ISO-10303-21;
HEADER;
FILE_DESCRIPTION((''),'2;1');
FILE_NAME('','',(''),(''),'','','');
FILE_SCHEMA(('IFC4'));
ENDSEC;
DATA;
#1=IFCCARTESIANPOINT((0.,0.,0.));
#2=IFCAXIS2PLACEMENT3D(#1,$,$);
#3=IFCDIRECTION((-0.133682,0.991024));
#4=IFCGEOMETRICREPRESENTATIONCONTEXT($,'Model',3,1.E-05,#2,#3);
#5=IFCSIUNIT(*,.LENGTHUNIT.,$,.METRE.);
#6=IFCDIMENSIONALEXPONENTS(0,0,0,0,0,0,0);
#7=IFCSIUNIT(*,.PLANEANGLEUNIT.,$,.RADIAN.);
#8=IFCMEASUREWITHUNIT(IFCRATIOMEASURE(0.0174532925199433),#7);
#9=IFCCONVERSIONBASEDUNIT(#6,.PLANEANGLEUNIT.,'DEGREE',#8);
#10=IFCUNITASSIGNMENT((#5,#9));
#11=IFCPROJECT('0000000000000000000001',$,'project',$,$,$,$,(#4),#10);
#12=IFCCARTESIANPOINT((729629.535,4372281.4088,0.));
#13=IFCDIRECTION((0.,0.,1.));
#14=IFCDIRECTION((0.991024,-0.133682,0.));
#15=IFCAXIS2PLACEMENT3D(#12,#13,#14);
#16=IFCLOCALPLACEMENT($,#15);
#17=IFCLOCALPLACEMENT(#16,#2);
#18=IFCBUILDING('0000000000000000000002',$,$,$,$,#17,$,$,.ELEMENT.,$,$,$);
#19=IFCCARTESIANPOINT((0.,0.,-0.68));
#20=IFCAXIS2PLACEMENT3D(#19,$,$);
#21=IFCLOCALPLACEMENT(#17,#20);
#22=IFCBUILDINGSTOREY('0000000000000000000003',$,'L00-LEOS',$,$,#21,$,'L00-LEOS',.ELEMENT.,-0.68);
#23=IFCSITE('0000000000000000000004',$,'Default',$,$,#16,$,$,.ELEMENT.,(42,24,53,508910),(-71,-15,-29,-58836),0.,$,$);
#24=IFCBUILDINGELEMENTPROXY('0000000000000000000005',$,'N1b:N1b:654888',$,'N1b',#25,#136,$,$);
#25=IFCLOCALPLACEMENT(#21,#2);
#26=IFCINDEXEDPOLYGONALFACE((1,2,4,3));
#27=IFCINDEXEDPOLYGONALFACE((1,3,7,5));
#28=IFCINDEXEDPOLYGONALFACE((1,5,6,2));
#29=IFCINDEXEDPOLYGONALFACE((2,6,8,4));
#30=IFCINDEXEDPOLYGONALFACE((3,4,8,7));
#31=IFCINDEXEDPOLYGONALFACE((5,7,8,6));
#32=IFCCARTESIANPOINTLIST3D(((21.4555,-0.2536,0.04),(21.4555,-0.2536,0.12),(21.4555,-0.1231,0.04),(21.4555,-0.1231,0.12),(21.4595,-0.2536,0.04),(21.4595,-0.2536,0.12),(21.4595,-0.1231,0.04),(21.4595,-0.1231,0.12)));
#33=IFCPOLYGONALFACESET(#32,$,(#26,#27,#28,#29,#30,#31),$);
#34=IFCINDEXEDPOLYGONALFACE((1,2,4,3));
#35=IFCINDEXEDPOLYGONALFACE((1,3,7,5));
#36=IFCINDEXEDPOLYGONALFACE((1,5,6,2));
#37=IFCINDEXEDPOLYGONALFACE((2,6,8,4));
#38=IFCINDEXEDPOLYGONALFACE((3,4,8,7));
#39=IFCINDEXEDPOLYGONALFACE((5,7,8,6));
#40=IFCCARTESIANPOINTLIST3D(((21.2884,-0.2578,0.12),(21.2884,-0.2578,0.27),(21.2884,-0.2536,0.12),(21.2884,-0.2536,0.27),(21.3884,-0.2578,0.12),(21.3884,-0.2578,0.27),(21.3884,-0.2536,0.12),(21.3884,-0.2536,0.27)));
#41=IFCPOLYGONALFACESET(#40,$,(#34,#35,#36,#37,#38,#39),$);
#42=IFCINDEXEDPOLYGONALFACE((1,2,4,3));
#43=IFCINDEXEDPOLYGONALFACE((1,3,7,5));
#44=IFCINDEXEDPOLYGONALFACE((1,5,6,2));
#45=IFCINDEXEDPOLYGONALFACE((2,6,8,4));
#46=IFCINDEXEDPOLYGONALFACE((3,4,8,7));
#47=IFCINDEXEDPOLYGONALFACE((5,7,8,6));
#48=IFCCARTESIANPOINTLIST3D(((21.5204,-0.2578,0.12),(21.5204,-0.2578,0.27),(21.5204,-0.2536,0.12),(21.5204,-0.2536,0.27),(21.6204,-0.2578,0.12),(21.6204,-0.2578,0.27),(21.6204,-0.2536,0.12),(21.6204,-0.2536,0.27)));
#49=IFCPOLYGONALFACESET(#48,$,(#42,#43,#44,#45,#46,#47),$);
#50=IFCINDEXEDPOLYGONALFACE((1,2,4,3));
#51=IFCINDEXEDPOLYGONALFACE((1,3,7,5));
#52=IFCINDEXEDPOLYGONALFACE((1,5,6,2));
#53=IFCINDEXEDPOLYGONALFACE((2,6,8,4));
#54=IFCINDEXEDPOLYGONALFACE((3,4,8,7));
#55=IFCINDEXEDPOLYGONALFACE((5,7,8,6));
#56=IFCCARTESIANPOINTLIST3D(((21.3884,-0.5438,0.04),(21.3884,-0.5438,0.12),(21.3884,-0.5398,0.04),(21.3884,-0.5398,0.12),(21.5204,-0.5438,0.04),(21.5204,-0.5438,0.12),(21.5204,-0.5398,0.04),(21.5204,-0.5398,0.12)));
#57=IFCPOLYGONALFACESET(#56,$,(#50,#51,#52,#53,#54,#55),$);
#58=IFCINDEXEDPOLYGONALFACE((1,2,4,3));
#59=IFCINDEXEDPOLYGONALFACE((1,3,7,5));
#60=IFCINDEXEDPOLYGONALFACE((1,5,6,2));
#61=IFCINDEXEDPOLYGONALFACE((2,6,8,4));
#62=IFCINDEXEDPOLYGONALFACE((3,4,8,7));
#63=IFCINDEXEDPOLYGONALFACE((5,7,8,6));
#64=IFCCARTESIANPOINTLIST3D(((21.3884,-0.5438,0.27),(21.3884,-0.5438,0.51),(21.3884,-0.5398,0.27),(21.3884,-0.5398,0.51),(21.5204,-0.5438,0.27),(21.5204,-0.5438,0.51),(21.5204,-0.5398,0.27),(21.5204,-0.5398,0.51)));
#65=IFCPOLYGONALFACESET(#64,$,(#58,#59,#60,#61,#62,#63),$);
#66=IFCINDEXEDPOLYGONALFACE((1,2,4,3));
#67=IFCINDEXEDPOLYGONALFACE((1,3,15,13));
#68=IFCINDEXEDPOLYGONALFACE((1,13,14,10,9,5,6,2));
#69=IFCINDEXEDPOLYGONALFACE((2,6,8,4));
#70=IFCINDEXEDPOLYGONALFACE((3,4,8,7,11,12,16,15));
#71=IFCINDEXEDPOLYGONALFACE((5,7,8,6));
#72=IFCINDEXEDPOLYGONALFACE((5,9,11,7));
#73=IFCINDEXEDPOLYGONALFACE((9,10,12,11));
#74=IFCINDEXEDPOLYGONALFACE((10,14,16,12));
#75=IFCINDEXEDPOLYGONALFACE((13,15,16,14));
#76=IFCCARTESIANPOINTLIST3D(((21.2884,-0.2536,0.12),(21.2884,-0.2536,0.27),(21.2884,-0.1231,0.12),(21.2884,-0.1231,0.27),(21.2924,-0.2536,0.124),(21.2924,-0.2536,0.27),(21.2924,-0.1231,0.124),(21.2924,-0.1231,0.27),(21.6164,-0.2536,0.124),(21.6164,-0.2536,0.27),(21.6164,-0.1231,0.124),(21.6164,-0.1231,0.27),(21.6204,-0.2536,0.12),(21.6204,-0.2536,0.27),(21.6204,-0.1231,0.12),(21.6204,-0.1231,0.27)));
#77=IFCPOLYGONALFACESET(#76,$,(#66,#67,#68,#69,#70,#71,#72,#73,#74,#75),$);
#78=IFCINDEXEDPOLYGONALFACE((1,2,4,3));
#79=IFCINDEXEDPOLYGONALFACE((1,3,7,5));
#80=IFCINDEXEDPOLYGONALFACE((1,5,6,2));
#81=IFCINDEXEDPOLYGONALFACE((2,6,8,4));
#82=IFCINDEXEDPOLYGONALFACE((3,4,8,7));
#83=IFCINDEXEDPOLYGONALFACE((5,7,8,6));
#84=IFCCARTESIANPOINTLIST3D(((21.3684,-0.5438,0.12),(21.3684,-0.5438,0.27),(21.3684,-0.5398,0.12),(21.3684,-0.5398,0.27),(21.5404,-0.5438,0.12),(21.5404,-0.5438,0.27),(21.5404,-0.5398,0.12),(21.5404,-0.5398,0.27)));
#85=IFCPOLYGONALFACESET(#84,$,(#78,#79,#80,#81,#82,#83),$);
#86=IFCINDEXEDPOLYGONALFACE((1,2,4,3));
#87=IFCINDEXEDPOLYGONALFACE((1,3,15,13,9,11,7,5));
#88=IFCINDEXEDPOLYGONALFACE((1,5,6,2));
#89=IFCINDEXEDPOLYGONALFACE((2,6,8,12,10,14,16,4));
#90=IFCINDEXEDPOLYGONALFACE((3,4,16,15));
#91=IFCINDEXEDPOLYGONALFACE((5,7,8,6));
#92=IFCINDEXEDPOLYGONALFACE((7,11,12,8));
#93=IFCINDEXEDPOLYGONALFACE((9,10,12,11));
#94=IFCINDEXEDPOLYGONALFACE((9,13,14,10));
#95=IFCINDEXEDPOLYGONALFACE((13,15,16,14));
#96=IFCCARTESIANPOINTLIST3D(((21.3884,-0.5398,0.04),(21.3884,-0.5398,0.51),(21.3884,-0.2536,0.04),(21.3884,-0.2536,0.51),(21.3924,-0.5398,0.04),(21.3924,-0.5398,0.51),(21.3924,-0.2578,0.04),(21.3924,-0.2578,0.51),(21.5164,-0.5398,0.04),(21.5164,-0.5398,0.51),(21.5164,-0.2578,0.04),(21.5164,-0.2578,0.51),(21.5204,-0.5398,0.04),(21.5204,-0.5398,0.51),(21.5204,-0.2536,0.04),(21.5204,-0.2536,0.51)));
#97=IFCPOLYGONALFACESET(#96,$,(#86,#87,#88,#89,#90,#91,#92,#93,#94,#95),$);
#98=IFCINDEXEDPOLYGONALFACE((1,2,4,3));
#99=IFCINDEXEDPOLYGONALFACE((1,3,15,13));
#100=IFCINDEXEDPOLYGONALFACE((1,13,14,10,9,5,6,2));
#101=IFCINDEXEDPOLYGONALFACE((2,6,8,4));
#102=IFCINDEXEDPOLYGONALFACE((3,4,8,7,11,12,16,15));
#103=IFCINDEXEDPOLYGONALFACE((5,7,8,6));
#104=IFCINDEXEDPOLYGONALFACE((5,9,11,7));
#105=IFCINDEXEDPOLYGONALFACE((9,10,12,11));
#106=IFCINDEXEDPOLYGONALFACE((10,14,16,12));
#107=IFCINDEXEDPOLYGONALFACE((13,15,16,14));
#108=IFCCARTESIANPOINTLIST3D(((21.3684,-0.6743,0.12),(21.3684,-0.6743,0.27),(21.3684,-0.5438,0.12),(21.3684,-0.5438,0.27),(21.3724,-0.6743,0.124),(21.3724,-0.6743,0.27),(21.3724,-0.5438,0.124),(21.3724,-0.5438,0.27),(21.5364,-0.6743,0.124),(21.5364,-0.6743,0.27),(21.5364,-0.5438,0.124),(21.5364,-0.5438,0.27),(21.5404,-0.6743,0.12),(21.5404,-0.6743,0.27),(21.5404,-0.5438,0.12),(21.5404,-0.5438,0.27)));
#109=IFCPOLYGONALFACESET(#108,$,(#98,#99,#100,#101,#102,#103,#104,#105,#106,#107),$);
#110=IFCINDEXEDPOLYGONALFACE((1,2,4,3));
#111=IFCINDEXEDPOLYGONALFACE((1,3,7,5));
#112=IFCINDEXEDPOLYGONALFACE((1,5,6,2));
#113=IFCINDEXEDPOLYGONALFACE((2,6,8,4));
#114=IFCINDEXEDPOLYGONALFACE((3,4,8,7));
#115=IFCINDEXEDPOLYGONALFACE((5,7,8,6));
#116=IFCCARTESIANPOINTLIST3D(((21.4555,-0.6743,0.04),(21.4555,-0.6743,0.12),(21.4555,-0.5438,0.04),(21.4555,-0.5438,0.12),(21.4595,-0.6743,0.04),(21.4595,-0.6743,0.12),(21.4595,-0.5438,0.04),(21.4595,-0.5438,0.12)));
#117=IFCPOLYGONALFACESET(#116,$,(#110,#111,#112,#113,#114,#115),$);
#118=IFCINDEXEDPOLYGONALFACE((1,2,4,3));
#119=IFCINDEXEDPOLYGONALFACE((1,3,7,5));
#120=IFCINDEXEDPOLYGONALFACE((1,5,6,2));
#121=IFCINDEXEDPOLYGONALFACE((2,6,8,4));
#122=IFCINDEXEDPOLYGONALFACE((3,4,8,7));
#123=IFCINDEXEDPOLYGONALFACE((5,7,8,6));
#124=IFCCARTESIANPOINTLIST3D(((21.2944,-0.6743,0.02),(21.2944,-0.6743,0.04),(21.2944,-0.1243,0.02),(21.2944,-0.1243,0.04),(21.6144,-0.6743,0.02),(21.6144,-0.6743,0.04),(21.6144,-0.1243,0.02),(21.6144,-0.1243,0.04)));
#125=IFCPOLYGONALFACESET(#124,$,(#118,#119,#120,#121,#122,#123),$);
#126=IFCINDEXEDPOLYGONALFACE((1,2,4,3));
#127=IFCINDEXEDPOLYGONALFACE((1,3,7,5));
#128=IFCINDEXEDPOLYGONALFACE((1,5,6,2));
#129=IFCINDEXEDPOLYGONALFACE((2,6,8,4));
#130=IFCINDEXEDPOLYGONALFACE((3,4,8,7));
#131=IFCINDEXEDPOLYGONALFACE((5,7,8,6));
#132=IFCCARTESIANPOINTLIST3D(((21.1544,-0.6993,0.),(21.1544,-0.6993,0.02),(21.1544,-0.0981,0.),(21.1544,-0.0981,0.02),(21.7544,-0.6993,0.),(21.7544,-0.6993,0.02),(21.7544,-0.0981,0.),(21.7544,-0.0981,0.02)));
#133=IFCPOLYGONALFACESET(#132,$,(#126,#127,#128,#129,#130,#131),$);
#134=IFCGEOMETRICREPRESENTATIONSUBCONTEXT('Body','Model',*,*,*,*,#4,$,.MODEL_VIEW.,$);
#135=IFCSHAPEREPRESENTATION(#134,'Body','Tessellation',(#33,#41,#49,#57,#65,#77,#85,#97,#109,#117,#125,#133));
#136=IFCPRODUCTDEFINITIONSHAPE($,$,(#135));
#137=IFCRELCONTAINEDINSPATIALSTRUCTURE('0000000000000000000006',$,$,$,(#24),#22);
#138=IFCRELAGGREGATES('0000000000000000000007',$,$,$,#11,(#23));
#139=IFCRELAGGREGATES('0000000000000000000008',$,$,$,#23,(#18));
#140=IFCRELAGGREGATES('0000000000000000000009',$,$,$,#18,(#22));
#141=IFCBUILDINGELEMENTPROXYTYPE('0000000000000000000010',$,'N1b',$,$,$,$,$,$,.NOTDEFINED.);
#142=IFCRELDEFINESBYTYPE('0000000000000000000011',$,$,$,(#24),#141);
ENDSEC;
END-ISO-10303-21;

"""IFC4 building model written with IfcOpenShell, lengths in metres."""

from ifc_helpers import new_model, entity, si_unit, converted_unit, direction, frame, frame_2d, origin, origin_2d_with_axis, place, context, subcontext, project, spatial, polyline, rectangle, outline, extrude, source, transform, mapped, type_object, type_shapes, element, save


model = new_model("IFC4")

# Units and contexts
model_context = context("Model", 3, precision=1e-05, world=origin(), true_north=direction((-0.133682, 0.991024)))
body_context = subcontext(model_context, "Body", "Model", "MODEL_VIEW")
ifc_project = project(units=[si_unit("LENGTHUNIT", "METRE"), converted_unit("PLANEANGLEUNIT", "DEGREE", entity("IfcRatioMeasure", 0.0174532925199433), si_unit("PLANEANGLEUNIT", "RADIAN"), dimensions=[0, 0, 0, 0, 0, 0, 0])], contexts=[model_context])

# Site, building, storey
site_placement = place(None, frame((729629.535, 4372281.4088, 0.0), z_axis=(0.0, 0.0, 1.0), x_axis=(0.991024, -0.133682, 0.0)))
site = spatial("IfcSite", under=ifc_project, at=site_placement, Name="Default", CompositionType="ELEMENT", RefLatitude=(42, 24, 53, 508910), RefLongitude=(-71, -15, -29, -58836), RefElevation=0.0)
building_placement = place(site_placement, origin())
building = spatial("IfcBuilding", under=site, at=building_placement, CompositionType="ELEMENT")
storey_placement = place(building_placement, frame((0.0, 0.0, -0.68)))
storey = spatial("IfcBuildingStorey", under=building, at=storey_placement, Name="L00-LEOS", LongName="L00-LEOS", CompositionType="ELEMENT", Elevation=-0.68)

# Building element proxy
building_element_proxy_type_1 = type_object("IfcBuildingElementProxyType", Name="N1b")
shared_shape_1 = source(origin(), body_context, "Body", "SweptSolid", [
    extrude(rectangle(XDim=0.004, YDim=0.1305, at=origin_2d_with_axis()), frame((0.2103, 0.0, 0.04), z_axis=(0.0, 0.0, 1.0), x_axis=(0.0, -1.0, 0.0)), (0.0, 0.0, 1.0), 0.08),
    extrude(rectangle(XDim=0.1, YDim=0.0042, at=frame_2d((0.0, 0.0), x_axis=(1.0, 0.0))), frame((0.143, 0.1191, 0.12), z_axis=(0.0, 0.0, 1.0), x_axis=(0.0, 1.0, 0.0)), (0.0, 0.0, 1.0), 0.15),
    extrude(rectangle(XDim=0.1, YDim=0.0042, at=origin_2d_with_axis()), frame((0.143, -0.1129, 0.12), z_axis=(0.0, 0.0, 1.0), x_axis=(0.0, 1.0, 0.0)), (0.0, 0.0, 1.0), 0.15),
    extrude(rectangle(XDim=0.132, YDim=0.004, at=frame_2d((0.0, 0.0), x_axis=(1.0, 0.0))), frame((-0.1431, 0.0031, 0.04), z_axis=(0.0, 0.0, 1.0), x_axis=(0.0, 1.0, 0.0)), (0.0, 0.0, 1.0), 0.08),
    extrude(rectangle(XDim=0.132, YDim=0.004, at=frame_2d((0.0, 0.0), x_axis=(1.0, 0.0))), frame((-0.1431, 0.0031, 0.27), z_axis=(0.0, 0.0, 1.0), x_axis=(0.0, 1.0, 0.0)), (0.0, 0.0, 1.0), 0.24),
    extrude(outline(polyline([(-0.076, -0.166), (0.074, -0.166), (0.074, -0.162), (-0.072, -0.162), (-0.072, 0.162), (0.074, 0.162), (0.074, 0.166), (-0.076, 0.166), (-0.076, -0.166)])), frame((0.1451, 0.0031, 0.196), z_axis=(1.0, 0.0, 0.0), x_axis=(0.0, 0.0, 1.0)), (0.0, 0.0, 1.0), 0.1305),
    extrude(rectangle(XDim=0.172, YDim=0.004, at=frame_2d((0.0, 0.0), x_axis=(1.0, 0.0))), frame((-0.1431, 0.0031, 0.12), z_axis=(0.0, 0.0, 1.0), x_axis=(0.0, 1.0, 0.0)), (0.0, 0.0, 1.0), 0.15),
    extrude(outline(polyline([(-0.1441, -0.066), (0.142, -0.066), (0.142, -0.062), (-0.14, -0.062), (-0.14, 0.062), (0.142, 0.062), (0.142, 0.066), (-0.1441, 0.066), (-0.1441, -0.066)])), frame((0.001, 0.0031, 0.04), z_axis=(0.0, 0.0, 1.0), x_axis=(-1.0, 0.0, 0.0)), (0.0, 0.0, 1.0), 0.47),
    extrude(outline(polyline([(-0.076, -0.086), (0.074, -0.086), (0.074, -0.082), (-0.072, -0.082), (-0.072, 0.082), (0.074, 0.082), (0.074, 0.086), (-0.076, 0.086), (-0.076, -0.086)])), frame((-0.2756, 0.0031, 0.196), z_axis=(1.0, 0.0, 0.0), x_axis=(0.0, 0.0, 1.0)), (0.0, 0.0, 1.0), 0.1305),
    extrude(rectangle(XDim=0.004, YDim=0.1305, at=origin_2d_with_axis()), frame((-0.2103, 0.0, 0.04), z_axis=(0.0, 0.0, 1.0), x_axis=(0.0, -1.0, 0.0)), (0.0, 0.0, 1.0), 0.08),
    extrude(rectangle(XDim=0.55, YDim=0.32, at=frame_2d((0.0, 0.0), x_axis=(1.0, 0.0))), frame((-0.0006, 0.0031, 0.02), z_axis=(0.0, 0.0, 1.0), x_axis=(-1.0, 0.0, 0.0)), (0.0, 0.0, 1.0), 0.02),
    extrude(rectangle(XDim=0.6012, YDim=0.6, at=frame_2d((0.0, 0.0), x_axis=(1.0, 0.0))), frame((0.0, 0.0031, 0.0), z_axis=(0.0, 0.0, 1.0), x_axis=(-1.0, 0.0, 0.0)), (0.0, 0.0, 1.0), 0.02),
])
type_shapes(building_element_proxy_type_1, [shared_shape_1])
for number, where, z_axis, x_axis, name in (
    (1, (21.4575, -0.3987, 0.0), (0.0, 0.0, 1.0), (0.0, 1.0, 0.0), "N1b:N1b:654888"),
):
    element("IfcBuildingElementProxy", number, at=place(storey_placement, frame(where, z_axis=z_axis, x_axis=x_axis)), inside=storey, type_object=building_element_proxy_type_1, Name=name, ObjectType="N1b", context=body_context, shape_type="MappedRepresentation", body=[
        mapped(shared_shape_1, transform((0.0, 0.0, 0.0), scale=1.0)),
    ])

save(model, "model.ifc")
